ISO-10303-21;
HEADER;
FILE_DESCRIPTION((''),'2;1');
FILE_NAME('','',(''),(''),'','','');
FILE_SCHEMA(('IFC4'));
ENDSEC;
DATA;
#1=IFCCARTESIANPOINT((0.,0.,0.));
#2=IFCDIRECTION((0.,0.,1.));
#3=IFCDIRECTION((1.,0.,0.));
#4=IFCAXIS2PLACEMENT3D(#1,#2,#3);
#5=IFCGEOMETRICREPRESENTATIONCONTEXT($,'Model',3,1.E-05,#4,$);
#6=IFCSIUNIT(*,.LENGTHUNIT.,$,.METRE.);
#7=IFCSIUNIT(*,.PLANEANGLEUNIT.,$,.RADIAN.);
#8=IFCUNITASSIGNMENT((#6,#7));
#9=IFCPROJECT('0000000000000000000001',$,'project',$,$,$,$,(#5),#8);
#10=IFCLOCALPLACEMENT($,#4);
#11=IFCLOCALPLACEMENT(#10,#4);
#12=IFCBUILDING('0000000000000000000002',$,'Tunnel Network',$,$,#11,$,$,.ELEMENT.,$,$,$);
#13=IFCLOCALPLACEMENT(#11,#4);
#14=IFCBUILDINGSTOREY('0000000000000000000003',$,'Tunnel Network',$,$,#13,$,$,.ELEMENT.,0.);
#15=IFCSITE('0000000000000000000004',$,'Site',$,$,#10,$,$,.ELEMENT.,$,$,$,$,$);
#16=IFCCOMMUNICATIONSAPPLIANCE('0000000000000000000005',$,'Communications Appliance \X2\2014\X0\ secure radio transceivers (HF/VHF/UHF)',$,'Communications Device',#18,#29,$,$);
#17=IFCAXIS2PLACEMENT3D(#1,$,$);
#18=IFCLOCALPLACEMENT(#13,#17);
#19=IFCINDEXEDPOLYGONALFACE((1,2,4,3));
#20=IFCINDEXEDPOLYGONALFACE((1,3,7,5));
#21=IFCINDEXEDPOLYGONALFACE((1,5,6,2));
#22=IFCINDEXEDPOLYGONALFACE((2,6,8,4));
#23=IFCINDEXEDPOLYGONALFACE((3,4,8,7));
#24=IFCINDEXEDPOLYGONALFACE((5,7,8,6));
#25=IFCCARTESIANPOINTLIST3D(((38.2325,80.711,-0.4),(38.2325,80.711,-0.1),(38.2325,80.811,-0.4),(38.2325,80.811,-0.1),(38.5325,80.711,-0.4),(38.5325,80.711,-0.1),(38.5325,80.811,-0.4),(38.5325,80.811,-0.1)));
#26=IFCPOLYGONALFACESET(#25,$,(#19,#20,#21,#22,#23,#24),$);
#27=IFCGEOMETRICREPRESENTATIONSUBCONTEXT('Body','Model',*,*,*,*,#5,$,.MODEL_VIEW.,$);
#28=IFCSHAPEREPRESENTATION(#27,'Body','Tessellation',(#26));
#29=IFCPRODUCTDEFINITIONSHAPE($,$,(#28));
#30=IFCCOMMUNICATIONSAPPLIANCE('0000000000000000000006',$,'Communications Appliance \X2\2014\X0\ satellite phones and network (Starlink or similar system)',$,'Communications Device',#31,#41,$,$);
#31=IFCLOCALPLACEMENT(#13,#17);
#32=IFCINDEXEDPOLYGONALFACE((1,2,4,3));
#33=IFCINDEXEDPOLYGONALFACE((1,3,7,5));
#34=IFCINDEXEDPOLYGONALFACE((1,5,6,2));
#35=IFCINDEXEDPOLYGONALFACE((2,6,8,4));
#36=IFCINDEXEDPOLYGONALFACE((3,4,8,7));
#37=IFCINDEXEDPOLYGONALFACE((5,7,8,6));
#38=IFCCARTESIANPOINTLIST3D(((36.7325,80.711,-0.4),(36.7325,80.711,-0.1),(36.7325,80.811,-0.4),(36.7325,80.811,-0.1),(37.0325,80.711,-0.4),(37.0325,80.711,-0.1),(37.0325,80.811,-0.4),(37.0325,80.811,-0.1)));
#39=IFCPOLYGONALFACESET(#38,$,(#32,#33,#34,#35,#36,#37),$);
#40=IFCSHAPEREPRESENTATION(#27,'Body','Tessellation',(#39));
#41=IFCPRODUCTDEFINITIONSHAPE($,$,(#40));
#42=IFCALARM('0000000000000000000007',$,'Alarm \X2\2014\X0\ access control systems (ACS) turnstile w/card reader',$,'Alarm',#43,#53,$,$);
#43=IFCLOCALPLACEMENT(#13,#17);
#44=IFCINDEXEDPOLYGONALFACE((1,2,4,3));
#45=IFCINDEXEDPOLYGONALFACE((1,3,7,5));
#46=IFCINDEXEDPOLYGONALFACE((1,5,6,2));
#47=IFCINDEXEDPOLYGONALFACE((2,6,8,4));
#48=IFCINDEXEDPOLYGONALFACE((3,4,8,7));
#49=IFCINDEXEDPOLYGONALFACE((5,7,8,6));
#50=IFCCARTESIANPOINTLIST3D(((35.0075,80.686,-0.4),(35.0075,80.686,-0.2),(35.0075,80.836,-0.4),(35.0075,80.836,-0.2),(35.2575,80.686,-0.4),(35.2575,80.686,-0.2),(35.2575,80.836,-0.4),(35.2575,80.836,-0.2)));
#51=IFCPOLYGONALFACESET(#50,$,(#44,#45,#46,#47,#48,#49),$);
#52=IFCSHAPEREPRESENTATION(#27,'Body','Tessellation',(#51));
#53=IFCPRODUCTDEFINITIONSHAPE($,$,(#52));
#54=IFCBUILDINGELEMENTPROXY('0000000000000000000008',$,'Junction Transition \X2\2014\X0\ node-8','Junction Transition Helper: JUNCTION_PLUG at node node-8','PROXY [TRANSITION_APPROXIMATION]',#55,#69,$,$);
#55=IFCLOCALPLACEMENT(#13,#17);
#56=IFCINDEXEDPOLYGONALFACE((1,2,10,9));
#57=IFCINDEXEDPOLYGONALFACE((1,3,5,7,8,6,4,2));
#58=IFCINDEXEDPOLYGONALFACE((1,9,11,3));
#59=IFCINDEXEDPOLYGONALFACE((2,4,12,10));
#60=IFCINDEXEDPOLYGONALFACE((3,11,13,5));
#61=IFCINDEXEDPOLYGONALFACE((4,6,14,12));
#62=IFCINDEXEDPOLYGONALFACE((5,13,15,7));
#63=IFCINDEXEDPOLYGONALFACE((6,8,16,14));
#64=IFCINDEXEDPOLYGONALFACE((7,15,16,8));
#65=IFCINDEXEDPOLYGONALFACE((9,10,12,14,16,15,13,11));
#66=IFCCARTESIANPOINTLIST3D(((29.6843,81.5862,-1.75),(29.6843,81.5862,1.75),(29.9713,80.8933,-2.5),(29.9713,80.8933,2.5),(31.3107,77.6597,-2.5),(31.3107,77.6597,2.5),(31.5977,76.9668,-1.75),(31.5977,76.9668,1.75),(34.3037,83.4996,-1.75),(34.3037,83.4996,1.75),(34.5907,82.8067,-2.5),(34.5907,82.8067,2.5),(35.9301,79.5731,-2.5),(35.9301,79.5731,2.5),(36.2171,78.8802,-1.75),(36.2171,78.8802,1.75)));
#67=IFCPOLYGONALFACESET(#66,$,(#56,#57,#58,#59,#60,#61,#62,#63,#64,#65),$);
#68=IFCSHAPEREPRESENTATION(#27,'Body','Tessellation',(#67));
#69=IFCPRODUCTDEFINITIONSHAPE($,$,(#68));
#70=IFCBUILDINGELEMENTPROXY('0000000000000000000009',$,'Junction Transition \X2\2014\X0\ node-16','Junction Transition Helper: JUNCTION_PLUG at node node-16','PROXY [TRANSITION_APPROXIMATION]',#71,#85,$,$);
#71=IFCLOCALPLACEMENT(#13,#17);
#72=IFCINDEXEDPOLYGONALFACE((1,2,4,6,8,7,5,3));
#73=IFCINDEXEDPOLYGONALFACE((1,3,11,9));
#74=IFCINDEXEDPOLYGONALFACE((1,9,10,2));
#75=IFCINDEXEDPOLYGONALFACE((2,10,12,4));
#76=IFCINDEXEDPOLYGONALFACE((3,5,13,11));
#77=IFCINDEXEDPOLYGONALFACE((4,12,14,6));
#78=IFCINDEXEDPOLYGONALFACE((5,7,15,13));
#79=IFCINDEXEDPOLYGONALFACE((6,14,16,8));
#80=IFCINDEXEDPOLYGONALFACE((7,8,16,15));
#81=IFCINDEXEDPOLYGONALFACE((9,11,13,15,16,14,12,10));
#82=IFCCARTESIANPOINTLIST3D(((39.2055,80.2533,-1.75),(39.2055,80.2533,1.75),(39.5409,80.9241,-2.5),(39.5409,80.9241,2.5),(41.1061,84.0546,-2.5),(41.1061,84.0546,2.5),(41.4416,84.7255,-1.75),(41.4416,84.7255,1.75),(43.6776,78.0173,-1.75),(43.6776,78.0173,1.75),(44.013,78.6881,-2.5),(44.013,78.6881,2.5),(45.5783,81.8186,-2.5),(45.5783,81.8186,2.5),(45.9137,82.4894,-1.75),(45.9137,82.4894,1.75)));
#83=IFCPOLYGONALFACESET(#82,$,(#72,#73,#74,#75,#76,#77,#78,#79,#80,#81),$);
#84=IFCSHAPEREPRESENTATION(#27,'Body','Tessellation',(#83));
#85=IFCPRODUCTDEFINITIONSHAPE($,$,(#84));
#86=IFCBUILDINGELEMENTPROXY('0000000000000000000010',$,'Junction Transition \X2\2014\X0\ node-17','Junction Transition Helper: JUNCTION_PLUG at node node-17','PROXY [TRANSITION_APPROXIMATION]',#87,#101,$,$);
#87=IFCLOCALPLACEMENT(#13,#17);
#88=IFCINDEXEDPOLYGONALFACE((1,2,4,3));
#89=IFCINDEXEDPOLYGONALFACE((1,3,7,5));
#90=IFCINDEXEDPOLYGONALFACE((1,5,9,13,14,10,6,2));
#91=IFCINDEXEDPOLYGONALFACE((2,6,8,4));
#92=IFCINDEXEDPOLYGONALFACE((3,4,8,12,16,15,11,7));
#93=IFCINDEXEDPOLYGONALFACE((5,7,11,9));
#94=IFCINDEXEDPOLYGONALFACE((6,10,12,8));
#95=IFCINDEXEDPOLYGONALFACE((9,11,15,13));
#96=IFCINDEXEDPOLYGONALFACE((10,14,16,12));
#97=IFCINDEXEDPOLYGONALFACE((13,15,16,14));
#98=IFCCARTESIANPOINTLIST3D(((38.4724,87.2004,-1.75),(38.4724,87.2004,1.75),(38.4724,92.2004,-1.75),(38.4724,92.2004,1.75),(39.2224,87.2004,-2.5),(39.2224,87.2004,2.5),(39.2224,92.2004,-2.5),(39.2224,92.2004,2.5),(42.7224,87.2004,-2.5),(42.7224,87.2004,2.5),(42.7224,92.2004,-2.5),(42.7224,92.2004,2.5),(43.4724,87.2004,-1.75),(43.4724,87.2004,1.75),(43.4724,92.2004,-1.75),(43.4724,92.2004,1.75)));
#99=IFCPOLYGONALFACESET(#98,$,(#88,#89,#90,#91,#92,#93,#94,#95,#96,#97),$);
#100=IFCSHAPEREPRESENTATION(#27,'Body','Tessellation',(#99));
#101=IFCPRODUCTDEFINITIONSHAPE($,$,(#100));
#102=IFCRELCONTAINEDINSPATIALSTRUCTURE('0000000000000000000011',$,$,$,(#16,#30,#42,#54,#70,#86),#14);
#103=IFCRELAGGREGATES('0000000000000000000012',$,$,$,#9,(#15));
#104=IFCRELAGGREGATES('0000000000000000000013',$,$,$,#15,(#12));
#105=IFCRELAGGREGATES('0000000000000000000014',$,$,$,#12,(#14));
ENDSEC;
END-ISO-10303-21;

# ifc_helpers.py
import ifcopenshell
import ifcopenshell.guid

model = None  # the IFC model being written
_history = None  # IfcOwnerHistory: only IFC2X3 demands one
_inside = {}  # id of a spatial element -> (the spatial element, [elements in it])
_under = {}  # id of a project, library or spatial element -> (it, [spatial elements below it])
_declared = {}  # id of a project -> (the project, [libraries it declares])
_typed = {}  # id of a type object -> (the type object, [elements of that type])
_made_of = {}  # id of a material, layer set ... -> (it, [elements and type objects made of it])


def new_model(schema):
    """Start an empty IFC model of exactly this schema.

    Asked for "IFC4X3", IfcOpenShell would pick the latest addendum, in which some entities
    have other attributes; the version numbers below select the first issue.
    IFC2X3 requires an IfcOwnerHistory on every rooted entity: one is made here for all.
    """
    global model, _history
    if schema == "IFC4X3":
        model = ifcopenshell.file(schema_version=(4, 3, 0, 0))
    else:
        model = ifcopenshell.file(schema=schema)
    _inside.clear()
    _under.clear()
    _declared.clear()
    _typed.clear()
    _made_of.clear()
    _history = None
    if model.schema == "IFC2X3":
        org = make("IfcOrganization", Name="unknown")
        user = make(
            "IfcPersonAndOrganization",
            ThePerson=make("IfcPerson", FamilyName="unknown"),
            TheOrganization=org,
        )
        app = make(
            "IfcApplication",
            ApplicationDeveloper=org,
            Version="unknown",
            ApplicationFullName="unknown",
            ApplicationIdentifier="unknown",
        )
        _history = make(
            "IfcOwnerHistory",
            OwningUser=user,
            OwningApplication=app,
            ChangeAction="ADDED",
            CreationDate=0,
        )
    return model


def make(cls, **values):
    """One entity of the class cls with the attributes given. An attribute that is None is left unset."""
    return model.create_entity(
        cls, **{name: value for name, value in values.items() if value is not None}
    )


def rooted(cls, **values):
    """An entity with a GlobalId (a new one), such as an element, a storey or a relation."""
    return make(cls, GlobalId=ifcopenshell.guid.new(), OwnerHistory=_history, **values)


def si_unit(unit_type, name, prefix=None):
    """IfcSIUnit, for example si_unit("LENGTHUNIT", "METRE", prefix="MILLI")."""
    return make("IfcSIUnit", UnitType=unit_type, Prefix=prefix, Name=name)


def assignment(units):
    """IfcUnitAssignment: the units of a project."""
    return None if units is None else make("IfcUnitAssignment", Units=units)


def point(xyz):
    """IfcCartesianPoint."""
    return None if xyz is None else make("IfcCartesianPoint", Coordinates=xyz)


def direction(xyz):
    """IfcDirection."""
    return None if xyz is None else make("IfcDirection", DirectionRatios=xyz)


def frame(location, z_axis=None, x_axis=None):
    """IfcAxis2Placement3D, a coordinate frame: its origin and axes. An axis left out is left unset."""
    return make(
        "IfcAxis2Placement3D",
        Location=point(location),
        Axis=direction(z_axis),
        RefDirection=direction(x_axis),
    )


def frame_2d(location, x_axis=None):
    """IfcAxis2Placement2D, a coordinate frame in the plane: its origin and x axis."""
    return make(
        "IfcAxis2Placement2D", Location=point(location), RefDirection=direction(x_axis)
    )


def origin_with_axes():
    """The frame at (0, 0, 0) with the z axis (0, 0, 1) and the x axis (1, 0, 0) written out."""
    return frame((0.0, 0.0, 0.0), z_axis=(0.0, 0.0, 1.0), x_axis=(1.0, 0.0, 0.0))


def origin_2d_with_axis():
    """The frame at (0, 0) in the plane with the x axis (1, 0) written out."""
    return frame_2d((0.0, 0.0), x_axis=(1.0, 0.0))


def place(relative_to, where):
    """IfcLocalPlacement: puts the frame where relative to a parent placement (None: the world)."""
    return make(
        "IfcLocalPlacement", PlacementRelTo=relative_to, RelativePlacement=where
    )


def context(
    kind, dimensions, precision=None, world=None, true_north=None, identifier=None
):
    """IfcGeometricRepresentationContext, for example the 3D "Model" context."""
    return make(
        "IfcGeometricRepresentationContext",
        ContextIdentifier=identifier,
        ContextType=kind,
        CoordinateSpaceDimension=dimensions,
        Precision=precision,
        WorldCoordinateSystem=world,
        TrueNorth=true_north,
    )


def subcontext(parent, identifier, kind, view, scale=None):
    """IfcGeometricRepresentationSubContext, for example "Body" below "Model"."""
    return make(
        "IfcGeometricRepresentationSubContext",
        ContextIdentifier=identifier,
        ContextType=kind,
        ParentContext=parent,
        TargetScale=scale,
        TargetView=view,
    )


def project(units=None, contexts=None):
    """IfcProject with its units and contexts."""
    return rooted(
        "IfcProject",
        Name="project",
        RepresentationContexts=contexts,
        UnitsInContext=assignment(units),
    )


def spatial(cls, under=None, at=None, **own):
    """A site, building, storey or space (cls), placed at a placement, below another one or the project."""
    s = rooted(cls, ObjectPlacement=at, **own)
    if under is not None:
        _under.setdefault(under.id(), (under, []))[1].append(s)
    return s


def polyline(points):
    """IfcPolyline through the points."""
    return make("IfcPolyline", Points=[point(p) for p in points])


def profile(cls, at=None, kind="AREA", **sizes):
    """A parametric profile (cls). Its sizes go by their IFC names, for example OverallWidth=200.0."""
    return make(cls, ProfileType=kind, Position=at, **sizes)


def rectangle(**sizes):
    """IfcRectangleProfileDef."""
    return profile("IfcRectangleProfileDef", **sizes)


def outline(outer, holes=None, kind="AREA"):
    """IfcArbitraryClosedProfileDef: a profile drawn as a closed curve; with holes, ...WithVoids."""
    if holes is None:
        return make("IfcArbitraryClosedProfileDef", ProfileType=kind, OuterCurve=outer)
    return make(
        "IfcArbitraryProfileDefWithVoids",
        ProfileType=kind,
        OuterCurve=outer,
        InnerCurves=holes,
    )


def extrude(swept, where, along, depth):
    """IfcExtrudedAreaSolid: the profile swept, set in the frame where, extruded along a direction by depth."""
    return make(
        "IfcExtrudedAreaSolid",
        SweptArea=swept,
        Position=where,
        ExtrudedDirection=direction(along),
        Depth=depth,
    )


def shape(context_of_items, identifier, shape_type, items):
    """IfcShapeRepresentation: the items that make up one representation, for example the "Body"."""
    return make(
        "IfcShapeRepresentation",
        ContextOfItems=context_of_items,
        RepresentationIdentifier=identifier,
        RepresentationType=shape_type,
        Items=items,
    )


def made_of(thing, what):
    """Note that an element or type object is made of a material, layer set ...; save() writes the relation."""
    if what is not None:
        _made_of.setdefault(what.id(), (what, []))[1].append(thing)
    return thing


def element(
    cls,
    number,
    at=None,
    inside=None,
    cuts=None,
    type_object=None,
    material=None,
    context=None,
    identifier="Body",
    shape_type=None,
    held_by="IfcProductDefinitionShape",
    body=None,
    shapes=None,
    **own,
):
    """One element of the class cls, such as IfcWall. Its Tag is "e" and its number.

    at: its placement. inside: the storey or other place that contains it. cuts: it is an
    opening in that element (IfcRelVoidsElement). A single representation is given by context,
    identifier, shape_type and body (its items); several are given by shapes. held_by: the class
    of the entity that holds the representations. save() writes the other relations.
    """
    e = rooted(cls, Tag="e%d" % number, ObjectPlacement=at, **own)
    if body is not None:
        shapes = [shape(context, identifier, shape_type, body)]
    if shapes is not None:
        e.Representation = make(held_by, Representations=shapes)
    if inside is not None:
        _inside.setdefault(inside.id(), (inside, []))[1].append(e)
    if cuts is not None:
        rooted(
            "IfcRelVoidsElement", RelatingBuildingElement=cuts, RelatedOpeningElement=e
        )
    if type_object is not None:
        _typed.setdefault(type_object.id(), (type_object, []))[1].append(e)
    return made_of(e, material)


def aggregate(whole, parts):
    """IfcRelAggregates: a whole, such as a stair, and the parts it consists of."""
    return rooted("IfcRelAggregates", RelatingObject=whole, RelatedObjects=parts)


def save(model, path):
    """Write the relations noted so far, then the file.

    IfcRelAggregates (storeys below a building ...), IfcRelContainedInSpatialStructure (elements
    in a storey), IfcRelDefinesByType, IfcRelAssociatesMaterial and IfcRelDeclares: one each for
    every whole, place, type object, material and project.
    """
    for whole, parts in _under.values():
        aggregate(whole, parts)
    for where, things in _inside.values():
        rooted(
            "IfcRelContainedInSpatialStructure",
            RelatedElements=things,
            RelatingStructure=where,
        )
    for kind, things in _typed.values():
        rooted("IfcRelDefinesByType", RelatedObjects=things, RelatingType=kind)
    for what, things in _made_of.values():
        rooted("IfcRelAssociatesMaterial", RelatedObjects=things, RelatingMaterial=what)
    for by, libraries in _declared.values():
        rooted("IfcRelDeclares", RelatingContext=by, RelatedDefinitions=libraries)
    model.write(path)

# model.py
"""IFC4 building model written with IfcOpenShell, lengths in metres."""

from ifc_helpers import new_model, si_unit, frame, origin_with_axes, origin_2d_with_axis, place, context, subcontext, project, spatial, polyline, rectangle, outline, extrude, element, save


model = new_model("IFC4")

# Units and contexts
model_context = context("Model", 3, precision=1e-05, world=origin_with_axes())
body_context = subcontext(model_context, "Body", "Model", "MODEL_VIEW")
ifc_project = project(units=[si_unit("LENGTHUNIT", "METRE"), si_unit("PLANEANGLEUNIT", "RADIAN")], contexts=[model_context])

# Site, building, storey
site_placement = place(None, origin_with_axes())
site = spatial("IfcSite", under=ifc_project, at=site_placement, Name="Site", CompositionType="ELEMENT")
building_placement = place(site_placement, origin_with_axes())
building = spatial("IfcBuilding", under=site, at=building_placement, Name="Tunnel Network", CompositionType="ELEMENT")
storey_placement = place(building_placement, origin_with_axes())
storey = spatial("IfcBuildingStorey", under=building, at=storey_placement, Name="Tunnel Network", CompositionType="ELEMENT", Elevation=0.0)

# Communications appliances
for number, where, z_axis, x_axis, name in (
    (1, (38.3825, 80.761, -0.4), (0.0, 0.0, 1.0), (1.0, 0.0, 0.0), "Communications Appliance — secure radio transceivers (HF/VHF/UHF)"),
    (2, (36.8825, 80.761, -0.4), (0.0, 0.0, 1.0), (1.0, 0.0, 0.0), "Communications Appliance — satellite phones and network (Starlink or similar system)"),
):
    element("IfcCommunicationsAppliance", number, at=place(storey_placement, frame(where, z_axis=z_axis, x_axis=x_axis)), inside=storey, Name=name, ObjectType="Communications Device", context=body_context, shape_type="SweptSolid", body=[
        extrude(rectangle(XDim=0.3, YDim=0.1, at=origin_2d_with_axis()), origin_with_axes(), (0.0, 0.0, 1.0), 0.3),
    ])

# Alarm
alarm_placement = place(storey_placement, frame((35.1325, 80.761, -0.4), z_axis=(0.0, 0.0, 1.0), x_axis=(1.0, 0.0, 0.0)))
element("IfcAlarm", 3, at=alarm_placement, inside=storey, Name="Alarm — access control systems (ACS) turnstile w/card reader", ObjectType="Alarm", context=body_context, shape_type="SweptSolid", body=[
    extrude(rectangle(XDim=0.25, YDim=0.15, at=origin_2d_with_axis()), origin_with_axes(), (0.0, 0.0, 1.0), 0.2),
])

# Building element proxies
for number, where, z_axis, x_axis, name, description in (
    (4, (35.2604, 81.1899, 0.0), (-0.92388, -0.382683, 0.0), (-0.382683, 0.92388, 0.0), "Junction Transition — node-8", "Junction Transition Helper: JUNCTION_PLUG at node node-8"),
    (5, (44.7957, 80.2533, 0.0), (-0.894427, 0.447214, 0.0), (0.447214, 0.894427, 0.0), "Junction Transition — node-16", "Junction Transition Helper: JUNCTION_PLUG at node node-16"),
    (6, (40.9724, 87.2004, 0.0), (0.0, 1.0, 0.0), (1.0, 0.0, 0.0), "Junction Transition — node-17", "Junction Transition Helper: JUNCTION_PLUG at node node-17"),
):
    element("IfcBuildingElementProxy", number, at=place(storey_placement, frame(where, z_axis=z_axis, x_axis=x_axis)), inside=storey, Name=name, Description=description, ObjectType="PROXY [TRANSITION_APPROXIMATION]", context=body_context, shape_type="SweptSolid", body=[
        extrude(outline(polyline([(1.75, 2.5), (2.5, 1.75), (2.5, -1.75), (1.75, -2.5), (-1.75, -2.5), (-2.5, -1.75), (-2.5, 1.75), (-1.75, 2.5), (1.75, 2.5)])), origin_with_axes(), (0.0, 0.0, 1.0), 5.0),
    ])

save(model, "model.ifc")
